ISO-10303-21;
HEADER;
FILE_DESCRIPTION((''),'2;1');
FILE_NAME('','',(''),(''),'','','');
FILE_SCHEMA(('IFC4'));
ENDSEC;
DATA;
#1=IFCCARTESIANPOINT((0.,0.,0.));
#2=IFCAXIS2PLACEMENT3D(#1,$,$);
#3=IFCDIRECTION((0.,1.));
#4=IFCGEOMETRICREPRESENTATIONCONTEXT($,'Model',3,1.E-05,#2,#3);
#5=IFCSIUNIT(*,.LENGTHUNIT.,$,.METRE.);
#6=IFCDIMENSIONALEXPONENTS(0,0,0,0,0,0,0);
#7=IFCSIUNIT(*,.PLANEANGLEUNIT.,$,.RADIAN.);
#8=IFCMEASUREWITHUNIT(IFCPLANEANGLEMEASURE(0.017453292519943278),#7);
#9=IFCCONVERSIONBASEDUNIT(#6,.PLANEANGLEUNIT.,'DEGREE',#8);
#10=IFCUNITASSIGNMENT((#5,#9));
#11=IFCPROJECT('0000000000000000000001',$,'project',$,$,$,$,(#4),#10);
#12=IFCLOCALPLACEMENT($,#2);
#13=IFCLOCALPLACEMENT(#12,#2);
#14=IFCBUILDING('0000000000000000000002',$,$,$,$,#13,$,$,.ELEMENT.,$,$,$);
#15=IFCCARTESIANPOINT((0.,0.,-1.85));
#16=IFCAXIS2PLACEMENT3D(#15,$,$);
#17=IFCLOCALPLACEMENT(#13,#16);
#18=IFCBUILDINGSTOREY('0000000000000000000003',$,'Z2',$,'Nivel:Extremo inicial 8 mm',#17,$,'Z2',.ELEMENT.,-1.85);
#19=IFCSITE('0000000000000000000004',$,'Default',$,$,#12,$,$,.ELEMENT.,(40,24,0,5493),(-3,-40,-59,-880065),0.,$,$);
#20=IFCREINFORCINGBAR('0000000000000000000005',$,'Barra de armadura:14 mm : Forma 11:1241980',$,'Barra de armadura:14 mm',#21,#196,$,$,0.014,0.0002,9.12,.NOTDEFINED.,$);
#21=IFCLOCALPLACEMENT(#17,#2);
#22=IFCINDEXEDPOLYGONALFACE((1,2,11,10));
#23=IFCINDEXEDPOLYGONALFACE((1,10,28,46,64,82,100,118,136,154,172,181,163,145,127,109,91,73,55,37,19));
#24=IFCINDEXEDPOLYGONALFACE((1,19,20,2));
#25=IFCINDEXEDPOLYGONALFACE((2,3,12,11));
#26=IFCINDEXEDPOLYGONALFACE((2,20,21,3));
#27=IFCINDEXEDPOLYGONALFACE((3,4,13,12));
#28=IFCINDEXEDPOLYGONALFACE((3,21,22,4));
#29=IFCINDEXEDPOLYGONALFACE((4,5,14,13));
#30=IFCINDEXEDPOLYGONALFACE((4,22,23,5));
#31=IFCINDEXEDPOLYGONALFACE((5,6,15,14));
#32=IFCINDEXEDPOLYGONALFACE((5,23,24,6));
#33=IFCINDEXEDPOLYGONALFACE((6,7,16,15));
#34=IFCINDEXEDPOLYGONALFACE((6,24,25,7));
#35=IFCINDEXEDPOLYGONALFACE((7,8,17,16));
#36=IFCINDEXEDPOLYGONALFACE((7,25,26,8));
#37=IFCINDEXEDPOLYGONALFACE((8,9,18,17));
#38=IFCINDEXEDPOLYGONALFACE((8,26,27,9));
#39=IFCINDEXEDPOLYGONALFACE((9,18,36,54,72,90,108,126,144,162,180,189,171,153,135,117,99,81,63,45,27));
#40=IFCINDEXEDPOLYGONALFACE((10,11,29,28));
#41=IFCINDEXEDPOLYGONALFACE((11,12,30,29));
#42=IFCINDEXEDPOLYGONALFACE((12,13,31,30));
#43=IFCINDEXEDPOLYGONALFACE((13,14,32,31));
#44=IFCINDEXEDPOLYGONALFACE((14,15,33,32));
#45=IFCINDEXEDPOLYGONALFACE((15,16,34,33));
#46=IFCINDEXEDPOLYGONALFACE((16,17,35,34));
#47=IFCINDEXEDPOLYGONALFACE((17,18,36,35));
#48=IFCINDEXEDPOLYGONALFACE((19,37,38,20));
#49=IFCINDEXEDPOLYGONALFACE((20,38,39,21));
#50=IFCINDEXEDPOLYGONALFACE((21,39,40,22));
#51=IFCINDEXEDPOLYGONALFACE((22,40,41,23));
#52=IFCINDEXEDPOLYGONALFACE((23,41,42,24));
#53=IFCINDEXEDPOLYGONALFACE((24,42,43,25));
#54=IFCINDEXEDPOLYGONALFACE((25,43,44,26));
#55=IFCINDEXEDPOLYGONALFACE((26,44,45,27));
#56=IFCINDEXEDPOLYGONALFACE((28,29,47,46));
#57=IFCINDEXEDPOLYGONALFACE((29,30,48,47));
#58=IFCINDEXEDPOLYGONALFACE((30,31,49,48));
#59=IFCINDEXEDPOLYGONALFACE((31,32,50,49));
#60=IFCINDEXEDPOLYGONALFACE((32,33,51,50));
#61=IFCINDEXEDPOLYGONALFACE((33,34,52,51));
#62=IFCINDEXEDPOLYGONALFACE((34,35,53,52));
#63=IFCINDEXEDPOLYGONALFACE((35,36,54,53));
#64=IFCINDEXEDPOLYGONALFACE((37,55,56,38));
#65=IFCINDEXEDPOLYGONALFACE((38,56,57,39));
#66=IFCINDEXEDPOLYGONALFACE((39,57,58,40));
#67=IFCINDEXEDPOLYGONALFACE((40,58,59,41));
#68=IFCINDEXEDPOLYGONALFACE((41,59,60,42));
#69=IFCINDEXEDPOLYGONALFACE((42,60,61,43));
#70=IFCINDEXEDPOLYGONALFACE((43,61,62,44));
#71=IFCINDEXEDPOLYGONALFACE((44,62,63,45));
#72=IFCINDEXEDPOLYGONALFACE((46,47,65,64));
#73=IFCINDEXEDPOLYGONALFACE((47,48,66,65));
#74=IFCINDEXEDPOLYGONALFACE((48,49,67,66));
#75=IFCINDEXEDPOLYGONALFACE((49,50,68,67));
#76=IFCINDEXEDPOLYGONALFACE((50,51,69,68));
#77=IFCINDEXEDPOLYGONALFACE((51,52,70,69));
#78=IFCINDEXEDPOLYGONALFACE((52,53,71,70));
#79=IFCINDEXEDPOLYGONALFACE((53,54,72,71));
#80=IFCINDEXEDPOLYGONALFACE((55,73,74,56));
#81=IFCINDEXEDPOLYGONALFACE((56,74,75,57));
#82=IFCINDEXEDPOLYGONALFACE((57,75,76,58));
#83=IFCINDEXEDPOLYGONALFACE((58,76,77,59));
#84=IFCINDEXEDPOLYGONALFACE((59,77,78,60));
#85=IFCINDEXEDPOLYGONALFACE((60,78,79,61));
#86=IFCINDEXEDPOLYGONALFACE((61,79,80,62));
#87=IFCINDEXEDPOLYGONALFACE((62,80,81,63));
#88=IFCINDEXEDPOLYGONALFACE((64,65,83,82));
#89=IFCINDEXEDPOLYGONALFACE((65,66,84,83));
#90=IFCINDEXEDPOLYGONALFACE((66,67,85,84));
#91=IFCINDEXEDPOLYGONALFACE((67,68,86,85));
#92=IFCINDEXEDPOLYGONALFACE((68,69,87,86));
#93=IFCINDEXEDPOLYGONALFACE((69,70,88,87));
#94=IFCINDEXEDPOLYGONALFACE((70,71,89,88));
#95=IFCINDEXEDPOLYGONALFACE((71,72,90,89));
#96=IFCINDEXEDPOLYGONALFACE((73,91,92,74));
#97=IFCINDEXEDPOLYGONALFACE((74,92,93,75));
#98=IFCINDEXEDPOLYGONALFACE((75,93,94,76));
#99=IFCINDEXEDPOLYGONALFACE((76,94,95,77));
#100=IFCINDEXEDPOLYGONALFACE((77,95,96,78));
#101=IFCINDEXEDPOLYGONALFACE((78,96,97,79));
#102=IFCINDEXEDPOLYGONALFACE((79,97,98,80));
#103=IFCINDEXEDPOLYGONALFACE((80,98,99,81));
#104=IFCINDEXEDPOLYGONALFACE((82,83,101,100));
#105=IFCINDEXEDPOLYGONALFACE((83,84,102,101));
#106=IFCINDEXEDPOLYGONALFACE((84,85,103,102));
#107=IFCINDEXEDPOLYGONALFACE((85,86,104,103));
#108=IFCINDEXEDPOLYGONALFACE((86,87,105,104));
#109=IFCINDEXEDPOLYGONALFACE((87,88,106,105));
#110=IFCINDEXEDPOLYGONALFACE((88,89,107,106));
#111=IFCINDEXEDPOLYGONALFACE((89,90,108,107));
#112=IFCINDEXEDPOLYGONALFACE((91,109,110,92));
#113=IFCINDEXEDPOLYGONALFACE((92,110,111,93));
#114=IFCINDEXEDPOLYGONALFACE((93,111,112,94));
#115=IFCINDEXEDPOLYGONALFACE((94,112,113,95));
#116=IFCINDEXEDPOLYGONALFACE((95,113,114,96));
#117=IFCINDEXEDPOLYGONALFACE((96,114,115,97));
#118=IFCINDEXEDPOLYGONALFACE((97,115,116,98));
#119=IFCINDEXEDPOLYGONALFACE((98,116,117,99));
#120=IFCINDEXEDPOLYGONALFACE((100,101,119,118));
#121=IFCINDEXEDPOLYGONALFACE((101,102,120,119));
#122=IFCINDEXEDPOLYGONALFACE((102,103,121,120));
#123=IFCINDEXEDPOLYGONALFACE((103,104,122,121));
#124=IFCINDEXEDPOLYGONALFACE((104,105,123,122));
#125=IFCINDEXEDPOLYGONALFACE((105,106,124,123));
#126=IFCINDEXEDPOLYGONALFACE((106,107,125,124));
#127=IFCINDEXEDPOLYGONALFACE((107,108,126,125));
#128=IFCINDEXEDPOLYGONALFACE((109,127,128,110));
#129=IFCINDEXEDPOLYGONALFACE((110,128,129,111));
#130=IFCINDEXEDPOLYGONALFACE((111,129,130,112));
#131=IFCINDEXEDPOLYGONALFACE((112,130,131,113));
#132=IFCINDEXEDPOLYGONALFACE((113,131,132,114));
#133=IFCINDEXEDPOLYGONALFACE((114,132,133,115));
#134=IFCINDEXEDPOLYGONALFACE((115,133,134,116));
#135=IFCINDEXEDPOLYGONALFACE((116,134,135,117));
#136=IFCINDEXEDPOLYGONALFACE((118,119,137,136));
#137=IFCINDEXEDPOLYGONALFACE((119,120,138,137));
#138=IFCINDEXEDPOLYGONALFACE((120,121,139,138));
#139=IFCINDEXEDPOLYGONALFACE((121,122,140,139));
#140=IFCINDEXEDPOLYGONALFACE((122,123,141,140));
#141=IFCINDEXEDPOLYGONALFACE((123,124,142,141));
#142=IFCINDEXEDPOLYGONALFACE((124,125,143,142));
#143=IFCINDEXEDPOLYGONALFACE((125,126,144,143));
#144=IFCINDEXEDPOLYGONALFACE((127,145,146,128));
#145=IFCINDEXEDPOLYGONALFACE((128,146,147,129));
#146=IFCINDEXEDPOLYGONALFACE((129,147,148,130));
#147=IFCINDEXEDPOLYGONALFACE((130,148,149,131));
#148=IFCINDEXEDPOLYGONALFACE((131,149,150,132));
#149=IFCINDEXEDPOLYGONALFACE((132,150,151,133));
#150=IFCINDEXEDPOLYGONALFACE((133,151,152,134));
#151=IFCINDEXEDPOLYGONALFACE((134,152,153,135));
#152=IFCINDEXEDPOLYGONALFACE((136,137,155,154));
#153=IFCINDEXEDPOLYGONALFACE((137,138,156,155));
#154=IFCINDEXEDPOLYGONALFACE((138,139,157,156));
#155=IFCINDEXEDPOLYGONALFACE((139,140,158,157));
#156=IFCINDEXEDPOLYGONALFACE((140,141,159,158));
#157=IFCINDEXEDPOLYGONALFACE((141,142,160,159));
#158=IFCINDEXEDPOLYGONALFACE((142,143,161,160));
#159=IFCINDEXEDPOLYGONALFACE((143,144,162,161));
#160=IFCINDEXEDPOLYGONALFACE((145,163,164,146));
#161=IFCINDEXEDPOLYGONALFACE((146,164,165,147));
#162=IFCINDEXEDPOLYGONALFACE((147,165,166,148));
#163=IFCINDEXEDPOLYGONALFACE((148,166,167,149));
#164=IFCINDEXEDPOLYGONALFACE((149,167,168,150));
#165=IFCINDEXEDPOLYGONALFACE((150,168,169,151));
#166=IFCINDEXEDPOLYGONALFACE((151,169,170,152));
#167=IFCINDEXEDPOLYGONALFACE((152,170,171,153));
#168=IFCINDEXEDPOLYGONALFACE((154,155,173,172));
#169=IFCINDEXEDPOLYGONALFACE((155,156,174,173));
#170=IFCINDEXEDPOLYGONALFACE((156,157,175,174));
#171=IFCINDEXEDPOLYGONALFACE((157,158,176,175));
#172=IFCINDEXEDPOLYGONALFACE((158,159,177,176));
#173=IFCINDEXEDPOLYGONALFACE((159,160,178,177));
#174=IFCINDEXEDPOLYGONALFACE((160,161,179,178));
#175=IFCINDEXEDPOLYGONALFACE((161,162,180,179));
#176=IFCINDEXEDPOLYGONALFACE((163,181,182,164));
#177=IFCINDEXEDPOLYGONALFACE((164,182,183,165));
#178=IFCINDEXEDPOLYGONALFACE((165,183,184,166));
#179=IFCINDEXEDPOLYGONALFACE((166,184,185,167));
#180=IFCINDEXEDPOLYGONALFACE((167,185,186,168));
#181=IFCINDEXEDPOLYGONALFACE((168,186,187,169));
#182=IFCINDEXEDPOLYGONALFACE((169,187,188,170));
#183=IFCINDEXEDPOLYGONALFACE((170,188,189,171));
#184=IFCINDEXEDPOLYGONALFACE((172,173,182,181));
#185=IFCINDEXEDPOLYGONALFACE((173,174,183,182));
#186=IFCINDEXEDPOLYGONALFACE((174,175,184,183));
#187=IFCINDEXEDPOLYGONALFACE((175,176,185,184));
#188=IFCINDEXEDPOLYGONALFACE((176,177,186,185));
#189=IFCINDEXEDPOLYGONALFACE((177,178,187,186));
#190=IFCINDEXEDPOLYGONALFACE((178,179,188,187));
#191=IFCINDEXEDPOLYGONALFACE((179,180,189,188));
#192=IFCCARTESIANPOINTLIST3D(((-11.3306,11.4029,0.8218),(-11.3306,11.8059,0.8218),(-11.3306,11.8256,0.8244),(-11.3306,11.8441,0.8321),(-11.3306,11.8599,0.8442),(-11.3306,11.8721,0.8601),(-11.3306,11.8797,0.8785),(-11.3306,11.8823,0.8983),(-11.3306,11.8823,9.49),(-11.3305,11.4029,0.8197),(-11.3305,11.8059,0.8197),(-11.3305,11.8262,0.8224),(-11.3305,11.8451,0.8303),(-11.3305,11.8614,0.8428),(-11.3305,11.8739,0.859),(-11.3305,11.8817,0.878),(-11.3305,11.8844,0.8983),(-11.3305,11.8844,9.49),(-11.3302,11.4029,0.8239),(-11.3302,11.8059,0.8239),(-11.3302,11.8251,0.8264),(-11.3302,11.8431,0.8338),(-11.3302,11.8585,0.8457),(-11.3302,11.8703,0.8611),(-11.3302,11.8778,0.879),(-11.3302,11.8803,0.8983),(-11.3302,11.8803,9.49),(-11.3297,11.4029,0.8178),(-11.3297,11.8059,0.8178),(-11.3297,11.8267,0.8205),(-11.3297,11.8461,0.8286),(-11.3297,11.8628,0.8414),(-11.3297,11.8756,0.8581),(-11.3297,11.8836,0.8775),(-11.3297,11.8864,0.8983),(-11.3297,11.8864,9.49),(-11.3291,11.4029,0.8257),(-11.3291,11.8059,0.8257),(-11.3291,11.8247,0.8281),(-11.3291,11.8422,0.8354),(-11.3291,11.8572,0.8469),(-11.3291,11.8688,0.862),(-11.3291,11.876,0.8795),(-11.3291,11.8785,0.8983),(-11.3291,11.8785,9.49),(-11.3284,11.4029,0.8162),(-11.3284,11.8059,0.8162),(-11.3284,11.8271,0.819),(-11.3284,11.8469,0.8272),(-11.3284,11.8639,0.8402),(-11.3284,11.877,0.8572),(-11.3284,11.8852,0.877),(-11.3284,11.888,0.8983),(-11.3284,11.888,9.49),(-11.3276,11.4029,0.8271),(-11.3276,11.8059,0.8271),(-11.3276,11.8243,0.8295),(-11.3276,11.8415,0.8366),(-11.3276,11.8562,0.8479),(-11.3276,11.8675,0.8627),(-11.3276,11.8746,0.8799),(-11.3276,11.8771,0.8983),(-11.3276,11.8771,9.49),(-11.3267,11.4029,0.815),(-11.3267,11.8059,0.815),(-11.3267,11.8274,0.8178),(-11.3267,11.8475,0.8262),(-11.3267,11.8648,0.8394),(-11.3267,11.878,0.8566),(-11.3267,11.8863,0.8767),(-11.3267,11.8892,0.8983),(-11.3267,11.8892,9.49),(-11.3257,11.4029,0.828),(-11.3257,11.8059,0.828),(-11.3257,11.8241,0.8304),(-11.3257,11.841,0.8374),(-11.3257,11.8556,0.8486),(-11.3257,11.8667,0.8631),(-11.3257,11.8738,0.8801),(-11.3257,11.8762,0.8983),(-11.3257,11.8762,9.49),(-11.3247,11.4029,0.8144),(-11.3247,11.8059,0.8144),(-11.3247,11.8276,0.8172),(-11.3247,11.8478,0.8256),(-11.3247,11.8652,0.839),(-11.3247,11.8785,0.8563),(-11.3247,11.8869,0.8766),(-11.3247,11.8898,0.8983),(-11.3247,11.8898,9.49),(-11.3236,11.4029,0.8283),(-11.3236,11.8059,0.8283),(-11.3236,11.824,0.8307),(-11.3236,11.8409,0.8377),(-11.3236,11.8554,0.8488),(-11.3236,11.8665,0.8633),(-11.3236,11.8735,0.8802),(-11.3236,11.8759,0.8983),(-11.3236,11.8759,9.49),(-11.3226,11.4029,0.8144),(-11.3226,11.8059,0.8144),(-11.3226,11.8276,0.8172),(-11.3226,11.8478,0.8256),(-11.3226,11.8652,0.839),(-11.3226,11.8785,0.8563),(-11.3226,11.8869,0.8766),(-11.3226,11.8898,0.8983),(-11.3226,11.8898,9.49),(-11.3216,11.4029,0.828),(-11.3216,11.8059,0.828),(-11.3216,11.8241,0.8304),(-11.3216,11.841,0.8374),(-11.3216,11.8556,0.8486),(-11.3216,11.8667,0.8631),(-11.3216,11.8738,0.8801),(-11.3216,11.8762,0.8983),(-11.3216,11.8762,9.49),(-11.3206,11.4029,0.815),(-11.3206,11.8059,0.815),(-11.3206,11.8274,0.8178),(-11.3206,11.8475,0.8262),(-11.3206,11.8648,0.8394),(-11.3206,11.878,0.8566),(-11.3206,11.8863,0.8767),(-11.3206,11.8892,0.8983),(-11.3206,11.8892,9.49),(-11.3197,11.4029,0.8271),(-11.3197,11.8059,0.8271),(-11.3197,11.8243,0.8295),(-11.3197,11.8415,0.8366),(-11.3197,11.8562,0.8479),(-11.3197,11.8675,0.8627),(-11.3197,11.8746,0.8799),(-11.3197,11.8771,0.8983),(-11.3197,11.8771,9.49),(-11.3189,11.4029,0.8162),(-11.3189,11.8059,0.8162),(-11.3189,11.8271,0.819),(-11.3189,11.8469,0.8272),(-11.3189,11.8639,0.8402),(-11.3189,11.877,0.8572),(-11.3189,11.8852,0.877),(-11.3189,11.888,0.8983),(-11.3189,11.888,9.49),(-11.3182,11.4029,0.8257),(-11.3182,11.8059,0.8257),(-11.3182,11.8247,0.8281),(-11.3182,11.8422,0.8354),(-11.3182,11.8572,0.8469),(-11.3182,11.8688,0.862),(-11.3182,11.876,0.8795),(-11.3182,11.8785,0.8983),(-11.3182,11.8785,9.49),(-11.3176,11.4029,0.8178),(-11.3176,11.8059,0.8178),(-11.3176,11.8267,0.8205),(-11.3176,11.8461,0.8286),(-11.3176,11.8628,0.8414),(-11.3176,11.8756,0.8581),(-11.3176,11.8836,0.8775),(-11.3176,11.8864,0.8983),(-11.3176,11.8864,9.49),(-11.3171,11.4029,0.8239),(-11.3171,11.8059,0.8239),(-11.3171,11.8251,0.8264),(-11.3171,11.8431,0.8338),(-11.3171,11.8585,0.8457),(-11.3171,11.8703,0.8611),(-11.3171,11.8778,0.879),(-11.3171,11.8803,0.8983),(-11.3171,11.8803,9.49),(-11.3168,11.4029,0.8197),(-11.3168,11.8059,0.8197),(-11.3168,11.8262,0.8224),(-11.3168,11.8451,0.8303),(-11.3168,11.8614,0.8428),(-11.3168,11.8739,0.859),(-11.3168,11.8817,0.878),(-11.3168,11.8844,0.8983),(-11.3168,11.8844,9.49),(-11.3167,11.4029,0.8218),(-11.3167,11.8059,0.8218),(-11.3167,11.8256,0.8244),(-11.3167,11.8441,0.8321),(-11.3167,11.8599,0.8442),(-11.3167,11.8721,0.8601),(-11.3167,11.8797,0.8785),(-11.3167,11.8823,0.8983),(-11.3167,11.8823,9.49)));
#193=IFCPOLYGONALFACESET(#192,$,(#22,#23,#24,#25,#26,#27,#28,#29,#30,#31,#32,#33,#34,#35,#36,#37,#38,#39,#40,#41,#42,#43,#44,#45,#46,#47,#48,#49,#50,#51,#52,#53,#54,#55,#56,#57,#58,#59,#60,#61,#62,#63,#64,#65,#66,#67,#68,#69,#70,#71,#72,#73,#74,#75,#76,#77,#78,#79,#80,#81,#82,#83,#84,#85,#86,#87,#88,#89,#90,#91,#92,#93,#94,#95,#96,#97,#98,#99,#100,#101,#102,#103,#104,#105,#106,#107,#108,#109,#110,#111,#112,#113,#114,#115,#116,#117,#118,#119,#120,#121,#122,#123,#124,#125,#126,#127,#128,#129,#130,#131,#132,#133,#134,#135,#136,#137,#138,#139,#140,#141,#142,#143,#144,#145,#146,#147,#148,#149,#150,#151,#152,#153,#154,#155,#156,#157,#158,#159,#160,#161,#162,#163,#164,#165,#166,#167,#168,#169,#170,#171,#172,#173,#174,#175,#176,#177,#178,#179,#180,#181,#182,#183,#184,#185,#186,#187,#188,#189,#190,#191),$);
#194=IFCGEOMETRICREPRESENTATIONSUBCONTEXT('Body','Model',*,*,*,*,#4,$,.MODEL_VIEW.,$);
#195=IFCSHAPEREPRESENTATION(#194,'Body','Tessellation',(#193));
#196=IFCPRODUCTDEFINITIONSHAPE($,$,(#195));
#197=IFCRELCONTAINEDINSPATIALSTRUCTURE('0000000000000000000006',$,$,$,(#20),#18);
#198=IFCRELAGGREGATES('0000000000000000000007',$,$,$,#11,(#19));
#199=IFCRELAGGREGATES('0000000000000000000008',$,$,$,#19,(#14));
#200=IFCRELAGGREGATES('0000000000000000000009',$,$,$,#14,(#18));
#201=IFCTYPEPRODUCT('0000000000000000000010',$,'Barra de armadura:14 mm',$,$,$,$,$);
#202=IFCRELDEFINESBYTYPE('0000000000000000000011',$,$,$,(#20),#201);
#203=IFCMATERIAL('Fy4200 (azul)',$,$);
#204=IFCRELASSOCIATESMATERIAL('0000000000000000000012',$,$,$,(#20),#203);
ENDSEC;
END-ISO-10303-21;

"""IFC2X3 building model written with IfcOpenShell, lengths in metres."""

from ifc_helpers import new_model, entity, si_unit, converted_unit, direction, frame, origin, place, context, subcontext, project, spatial, material, type_object, element, save


model = new_model("IFC2X3")

# Units and contexts
model_context = context("Model", 3, precision=1e-05, world=origin(), true_north=direction((0.0, 1.0)))
body_context = subcontext(model_context, "Body", "Model", "MODEL_VIEW")
ifc_project = project(units=[si_unit("LENGTHUNIT", "METRE"), converted_unit("PLANEANGLEUNIT", "DEGREE", entity("IfcPlaneAngleMeasure", 0.017453292519943278), si_unit("PLANEANGLEUNIT", "RADIAN"), dimensions=[0, 0, 0, 0, 0, 0, 0])], contexts=[model_context])

# Site, building, storey
site_placement = place(None, origin())
site = spatial("IfcSite", under=ifc_project, at=site_placement, Name="Default", CompositionType="ELEMENT", RefLatitude=(40, 24, 0, 5493), RefLongitude=(-3, -40, -59, -880065), RefElevation=0.0)
building_placement = place(site_placement, origin())
building = spatial("IfcBuilding", under=site, at=building_placement, CompositionType="ELEMENT")
storey_placement = place(building_placement, frame((0.0, 0.0, -1.85)))
storey = spatial("IfcBuildingStorey", under=building, at=storey_placement, Name="Z2", ObjectType="Nivel:Extremo inicial 8 mm", LongName="Z2", CompositionType="ELEMENT", Elevation=-1.85)

# Reinforcing bar
ifc_material_1 = material(Name="Fy4200 (azul)")
type_product_1 = type_object("IfcTypeProduct", Name="Barra de armadura:14 mm")
reinforcing_bar_1_placement = place(storey_placement, origin())
element("IfcReinforcingBar", 1, at=reinforcing_bar_1_placement, inside=storey, type_object=type_product_1, material=ifc_material_1, Name="Barra de armadura:14 mm : Forma 11:1241980", ObjectType="Barra de armadura:14 mm", BarLength=9.12, BarRole="NOTDEFINED", CrossSectionArea=0.0002, NominalDiameter=0.014, context=body_context, shape_type="AdvancedSweptSolid", body=[
    entity("IfcSweptDiskSolid", entity("IfcCompositeCurve", [entity("IfcCompositeCurveSegment", "CONTINUOUS", True, entity("IfcPolyline", [entity("IfcCartesianPoint", [-11.3236, 11.8829, 9.49]), entity("IfcCartesianPoint", [-11.3236, 11.8829, 0.8983])])), entity("IfcCompositeCurveSegment", "CONTINUOUS", True, entity("IfcTrimmedCurve", entity("IfcCircle", entity("IfcAxis2Placement3D", entity("IfcCartesianPoint", [-11.3236, 11.8059, 0.8983]), entity("IfcDirection", [-1.0, 0.0, 0.0]), entity("IfcDirection", [0.0, 0.0, -1.0])), 0.077), [entity("IfcParameterValue", 270.0)], [entity("IfcParameterValue", 360.0)], True, "PARAMETER")), entity("IfcCompositeCurveSegment", "CONTINUOUS", True, entity("IfcPolyline", [entity("IfcCartesianPoint", [-11.3236, 11.8059, 0.8213]), entity("IfcCartesianPoint", [-11.3236, 11.4029, 0.8213])]))], False), 0.007, None, 0.0, 92.0),
])

save(model, "model.ifc")
